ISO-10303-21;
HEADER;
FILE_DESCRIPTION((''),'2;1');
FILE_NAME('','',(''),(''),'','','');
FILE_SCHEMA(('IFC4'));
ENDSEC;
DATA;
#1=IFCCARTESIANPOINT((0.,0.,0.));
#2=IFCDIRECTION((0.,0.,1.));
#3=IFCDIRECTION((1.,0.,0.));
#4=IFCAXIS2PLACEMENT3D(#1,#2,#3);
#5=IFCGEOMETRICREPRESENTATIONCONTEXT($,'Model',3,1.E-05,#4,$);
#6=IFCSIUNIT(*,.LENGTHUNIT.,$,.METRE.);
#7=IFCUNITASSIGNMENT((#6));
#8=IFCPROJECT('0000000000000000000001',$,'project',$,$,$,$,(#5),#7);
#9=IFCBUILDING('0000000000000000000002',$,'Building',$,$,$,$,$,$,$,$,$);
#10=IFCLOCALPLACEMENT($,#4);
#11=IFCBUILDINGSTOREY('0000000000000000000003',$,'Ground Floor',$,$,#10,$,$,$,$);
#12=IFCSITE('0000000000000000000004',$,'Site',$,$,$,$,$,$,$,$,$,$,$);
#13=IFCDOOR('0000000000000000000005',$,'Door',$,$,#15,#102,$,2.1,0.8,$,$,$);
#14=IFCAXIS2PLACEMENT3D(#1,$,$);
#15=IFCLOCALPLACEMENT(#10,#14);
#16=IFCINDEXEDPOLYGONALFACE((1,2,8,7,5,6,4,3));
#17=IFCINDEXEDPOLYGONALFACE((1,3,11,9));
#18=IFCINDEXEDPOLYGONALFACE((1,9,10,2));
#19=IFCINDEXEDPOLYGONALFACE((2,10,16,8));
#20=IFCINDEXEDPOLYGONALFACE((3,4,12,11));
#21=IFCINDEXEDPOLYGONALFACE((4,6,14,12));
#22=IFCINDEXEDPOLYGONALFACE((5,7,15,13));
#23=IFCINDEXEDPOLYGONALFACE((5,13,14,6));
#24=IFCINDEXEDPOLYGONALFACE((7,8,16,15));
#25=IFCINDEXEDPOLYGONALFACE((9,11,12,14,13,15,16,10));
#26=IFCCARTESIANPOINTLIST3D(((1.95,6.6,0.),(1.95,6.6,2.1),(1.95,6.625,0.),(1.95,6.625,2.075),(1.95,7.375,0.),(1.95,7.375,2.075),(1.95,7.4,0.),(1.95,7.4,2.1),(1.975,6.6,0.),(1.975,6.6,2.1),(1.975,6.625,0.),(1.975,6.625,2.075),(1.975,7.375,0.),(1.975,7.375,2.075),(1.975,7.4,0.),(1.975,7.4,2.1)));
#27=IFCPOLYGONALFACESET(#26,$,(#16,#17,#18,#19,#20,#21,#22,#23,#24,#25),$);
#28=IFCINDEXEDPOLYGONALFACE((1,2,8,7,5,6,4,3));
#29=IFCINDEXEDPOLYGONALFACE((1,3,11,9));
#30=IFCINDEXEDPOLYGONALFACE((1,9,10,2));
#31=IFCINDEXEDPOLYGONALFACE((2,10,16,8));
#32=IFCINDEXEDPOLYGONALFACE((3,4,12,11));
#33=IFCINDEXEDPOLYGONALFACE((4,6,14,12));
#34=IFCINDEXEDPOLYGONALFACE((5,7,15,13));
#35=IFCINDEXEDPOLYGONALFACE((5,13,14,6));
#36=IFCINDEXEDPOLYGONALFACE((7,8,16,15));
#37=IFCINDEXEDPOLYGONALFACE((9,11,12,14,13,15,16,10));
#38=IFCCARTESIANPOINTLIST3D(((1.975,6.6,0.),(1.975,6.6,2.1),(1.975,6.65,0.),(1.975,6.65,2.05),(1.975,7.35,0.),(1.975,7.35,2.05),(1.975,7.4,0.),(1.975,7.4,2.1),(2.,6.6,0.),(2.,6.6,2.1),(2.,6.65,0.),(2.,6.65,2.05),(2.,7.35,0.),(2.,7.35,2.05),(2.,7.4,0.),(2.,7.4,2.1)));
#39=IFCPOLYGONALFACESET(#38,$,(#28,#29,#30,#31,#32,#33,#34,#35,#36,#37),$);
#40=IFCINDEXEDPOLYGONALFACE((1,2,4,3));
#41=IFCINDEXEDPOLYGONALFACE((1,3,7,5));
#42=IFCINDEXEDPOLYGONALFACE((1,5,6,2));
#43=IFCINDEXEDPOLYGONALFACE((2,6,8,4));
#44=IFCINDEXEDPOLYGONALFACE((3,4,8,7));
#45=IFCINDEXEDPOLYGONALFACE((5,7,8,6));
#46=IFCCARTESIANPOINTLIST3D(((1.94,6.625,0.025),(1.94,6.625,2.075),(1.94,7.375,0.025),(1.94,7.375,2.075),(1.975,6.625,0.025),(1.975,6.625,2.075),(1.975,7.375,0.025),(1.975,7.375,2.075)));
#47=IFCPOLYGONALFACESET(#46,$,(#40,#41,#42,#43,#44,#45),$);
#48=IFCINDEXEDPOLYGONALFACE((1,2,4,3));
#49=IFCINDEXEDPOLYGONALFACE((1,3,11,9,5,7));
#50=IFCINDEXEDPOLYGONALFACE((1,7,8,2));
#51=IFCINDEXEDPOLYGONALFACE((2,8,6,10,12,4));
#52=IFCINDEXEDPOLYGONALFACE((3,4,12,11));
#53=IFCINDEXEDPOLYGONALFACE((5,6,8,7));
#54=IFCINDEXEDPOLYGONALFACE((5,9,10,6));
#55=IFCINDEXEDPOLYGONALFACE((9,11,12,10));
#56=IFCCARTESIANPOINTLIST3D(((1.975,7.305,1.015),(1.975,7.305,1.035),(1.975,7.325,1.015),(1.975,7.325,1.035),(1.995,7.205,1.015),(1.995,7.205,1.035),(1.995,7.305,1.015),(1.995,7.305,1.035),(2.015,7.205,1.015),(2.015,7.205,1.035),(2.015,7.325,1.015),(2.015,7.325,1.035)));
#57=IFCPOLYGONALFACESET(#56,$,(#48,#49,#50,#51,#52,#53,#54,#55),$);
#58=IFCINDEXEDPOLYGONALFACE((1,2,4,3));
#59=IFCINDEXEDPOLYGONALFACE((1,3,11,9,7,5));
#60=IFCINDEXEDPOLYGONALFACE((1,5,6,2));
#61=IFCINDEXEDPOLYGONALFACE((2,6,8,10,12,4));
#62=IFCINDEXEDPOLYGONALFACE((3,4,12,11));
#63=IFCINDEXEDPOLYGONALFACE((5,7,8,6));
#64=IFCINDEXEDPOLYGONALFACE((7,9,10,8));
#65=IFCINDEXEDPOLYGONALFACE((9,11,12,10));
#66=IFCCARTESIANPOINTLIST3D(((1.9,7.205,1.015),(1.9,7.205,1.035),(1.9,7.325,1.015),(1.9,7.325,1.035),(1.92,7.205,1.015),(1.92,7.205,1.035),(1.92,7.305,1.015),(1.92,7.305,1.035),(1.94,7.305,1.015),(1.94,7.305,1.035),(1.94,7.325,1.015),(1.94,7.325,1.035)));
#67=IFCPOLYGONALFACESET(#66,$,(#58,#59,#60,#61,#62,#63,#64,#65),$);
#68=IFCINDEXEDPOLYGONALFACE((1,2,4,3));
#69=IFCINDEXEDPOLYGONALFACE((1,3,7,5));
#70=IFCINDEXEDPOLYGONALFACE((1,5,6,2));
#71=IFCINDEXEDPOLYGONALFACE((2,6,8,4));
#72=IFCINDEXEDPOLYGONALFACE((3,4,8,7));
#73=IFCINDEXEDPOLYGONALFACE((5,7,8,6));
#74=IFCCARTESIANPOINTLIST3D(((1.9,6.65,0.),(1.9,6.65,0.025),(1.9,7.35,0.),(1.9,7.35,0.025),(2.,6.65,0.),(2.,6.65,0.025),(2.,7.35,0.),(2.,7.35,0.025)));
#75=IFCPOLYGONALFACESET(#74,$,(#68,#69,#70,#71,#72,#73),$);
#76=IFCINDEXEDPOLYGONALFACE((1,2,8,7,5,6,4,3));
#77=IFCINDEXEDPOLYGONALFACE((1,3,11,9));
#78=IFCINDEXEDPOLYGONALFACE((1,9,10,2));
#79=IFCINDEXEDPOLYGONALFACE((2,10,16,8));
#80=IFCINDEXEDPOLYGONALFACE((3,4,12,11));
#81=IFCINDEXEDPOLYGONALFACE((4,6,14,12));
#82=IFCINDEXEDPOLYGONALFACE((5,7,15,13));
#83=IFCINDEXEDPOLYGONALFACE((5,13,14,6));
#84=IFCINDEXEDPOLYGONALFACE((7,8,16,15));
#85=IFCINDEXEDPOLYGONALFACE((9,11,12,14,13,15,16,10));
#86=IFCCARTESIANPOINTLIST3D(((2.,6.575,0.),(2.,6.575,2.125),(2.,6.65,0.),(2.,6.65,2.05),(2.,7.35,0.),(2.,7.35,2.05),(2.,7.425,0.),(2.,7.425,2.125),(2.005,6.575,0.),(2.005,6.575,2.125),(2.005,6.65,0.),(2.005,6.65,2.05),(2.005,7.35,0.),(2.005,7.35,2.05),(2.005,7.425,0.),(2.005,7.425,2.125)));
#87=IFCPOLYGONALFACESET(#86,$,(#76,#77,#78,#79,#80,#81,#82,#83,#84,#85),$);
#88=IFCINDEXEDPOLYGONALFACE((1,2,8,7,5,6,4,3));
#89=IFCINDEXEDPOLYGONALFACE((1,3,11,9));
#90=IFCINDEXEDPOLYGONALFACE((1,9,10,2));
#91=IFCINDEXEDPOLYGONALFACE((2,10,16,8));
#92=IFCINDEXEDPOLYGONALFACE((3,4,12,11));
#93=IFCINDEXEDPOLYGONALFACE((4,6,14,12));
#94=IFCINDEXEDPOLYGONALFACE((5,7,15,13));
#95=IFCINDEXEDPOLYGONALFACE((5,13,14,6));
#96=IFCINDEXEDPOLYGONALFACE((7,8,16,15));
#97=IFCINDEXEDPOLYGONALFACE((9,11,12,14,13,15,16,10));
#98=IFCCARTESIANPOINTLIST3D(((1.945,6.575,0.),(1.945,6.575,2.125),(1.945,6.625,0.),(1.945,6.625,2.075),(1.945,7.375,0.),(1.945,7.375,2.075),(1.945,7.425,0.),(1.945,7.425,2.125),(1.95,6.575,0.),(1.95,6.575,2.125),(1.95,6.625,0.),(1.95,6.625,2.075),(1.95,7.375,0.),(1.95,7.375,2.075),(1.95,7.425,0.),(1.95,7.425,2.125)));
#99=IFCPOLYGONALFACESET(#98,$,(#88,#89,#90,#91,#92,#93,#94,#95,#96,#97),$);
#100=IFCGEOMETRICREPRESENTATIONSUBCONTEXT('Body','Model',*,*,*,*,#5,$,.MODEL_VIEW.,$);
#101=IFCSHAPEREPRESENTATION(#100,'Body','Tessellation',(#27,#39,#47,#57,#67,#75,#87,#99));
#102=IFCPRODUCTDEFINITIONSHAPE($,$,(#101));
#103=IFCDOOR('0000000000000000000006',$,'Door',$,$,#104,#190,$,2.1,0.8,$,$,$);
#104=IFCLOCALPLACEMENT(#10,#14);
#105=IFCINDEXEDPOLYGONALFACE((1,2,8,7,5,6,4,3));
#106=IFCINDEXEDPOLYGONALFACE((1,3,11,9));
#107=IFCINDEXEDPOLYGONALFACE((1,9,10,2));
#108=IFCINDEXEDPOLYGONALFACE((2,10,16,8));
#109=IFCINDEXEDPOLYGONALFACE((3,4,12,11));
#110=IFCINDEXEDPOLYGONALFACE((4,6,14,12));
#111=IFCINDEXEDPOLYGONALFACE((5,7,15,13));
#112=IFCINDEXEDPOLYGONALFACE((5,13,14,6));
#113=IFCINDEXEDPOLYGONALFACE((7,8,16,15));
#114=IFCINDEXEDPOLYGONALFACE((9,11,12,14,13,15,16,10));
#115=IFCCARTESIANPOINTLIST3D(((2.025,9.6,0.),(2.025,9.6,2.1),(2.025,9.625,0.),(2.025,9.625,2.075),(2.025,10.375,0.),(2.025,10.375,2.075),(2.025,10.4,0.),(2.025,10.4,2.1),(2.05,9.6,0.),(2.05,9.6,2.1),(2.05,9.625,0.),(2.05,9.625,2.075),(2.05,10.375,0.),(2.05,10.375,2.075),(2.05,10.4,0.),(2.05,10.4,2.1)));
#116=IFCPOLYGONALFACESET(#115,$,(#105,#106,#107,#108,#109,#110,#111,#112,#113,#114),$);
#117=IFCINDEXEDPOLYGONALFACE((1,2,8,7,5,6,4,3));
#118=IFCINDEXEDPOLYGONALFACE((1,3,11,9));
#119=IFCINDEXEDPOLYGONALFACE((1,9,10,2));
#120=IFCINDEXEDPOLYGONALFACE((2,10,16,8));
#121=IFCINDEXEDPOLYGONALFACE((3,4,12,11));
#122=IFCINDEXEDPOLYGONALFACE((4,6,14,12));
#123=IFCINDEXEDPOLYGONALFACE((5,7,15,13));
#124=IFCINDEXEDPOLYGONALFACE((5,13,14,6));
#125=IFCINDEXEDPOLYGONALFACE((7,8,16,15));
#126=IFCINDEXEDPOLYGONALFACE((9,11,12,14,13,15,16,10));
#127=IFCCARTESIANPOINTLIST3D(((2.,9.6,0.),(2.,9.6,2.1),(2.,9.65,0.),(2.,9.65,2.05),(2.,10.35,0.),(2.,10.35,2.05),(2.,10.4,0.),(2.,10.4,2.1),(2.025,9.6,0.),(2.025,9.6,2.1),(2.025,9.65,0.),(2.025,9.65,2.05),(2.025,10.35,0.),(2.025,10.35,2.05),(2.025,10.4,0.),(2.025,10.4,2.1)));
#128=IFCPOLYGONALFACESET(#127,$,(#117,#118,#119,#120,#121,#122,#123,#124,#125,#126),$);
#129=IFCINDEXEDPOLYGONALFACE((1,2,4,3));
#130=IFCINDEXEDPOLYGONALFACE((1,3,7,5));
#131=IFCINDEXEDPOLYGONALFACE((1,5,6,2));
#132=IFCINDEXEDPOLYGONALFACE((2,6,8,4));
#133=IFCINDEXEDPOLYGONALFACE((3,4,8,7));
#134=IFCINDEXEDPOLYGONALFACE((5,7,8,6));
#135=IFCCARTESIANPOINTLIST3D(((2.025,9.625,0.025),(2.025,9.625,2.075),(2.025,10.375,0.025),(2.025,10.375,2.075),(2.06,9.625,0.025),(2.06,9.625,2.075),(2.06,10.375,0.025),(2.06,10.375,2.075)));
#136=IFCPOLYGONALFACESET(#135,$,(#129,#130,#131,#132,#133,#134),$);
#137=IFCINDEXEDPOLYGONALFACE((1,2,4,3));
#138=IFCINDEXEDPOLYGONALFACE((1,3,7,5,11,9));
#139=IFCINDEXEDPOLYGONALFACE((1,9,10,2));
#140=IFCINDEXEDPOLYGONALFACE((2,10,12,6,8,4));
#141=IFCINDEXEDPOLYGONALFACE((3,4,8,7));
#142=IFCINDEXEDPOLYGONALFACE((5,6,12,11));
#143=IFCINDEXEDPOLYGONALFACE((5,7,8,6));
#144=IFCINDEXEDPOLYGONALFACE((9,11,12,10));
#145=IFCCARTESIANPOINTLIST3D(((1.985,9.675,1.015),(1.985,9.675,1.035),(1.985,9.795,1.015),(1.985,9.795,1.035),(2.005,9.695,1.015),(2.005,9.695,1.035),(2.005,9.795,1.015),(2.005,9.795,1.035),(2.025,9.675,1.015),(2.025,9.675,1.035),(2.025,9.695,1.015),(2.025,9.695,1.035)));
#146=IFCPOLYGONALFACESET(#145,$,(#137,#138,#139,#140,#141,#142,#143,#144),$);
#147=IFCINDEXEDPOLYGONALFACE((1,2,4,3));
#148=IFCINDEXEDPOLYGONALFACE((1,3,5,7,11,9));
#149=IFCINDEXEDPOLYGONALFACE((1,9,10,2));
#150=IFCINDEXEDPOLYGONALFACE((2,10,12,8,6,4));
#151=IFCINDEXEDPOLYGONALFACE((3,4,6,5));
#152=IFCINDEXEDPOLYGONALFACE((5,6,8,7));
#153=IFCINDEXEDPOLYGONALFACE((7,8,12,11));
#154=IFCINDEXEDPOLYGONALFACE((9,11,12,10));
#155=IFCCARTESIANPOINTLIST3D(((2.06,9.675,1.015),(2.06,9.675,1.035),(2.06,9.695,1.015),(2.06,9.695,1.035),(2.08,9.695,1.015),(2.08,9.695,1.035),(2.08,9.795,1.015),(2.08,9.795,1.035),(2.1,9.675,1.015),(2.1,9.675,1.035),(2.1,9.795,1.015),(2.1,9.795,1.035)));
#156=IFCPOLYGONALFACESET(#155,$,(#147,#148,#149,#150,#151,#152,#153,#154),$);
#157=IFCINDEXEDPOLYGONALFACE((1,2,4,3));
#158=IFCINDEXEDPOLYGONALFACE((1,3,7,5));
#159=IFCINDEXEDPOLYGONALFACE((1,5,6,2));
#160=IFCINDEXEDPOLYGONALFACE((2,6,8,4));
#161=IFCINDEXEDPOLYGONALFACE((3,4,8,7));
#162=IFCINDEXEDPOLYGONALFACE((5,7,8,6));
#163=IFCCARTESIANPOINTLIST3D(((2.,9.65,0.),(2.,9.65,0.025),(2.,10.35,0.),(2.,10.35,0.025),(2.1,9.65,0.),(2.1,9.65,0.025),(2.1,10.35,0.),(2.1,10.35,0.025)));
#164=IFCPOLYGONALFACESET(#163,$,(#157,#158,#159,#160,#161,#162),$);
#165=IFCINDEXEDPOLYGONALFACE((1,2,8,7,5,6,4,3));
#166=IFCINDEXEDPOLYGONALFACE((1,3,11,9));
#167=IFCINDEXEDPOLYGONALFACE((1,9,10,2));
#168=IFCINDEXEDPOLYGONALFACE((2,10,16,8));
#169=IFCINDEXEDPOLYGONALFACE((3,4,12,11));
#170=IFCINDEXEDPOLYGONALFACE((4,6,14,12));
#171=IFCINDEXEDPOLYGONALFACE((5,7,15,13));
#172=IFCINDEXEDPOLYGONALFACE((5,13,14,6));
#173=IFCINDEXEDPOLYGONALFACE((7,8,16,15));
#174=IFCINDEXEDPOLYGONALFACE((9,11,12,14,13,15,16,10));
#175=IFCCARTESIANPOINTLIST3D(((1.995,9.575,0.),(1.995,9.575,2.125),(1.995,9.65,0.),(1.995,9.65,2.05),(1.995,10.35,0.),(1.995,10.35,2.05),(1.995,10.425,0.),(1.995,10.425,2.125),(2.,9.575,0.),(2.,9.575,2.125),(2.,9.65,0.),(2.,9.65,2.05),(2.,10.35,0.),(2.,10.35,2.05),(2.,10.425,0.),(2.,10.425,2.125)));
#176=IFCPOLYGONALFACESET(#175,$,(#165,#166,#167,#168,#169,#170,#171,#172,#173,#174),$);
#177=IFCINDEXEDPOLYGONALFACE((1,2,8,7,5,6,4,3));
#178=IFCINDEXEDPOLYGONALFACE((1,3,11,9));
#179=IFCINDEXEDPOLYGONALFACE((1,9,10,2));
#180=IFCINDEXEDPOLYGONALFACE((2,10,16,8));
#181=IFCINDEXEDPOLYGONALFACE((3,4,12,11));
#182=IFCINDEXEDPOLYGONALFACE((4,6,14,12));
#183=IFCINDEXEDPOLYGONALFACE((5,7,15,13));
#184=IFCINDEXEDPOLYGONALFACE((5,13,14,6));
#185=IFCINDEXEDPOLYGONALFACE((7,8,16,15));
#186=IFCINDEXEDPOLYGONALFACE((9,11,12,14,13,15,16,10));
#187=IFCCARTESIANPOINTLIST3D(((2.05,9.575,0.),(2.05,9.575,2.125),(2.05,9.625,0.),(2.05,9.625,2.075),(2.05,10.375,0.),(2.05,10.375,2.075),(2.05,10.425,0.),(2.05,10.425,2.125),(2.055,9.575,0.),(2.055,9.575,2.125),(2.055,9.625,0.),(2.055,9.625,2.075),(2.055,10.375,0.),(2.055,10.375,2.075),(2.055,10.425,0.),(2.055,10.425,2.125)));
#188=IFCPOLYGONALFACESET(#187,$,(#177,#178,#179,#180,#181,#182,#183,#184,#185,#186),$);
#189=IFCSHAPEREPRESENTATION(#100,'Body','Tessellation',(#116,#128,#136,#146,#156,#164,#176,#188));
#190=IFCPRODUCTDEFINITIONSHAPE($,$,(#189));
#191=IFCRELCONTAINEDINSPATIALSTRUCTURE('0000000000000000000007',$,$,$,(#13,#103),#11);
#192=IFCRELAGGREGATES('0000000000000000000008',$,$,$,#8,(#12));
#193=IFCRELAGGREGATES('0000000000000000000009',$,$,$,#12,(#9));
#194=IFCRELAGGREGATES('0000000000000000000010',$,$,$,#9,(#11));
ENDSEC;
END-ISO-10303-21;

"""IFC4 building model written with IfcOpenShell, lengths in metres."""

from ifc_helpers import new_model, si_unit, frame, origin_with_axes, place, context, subcontext, project, spatial, line, indexed_curve, outline, extrude, element, save


model = new_model("IFC4")

# Units and contexts
model_context = context("Model", 3, precision=1e-05, world=origin_with_axes())
body_context = subcontext(model_context, "Body", "Model", "MODEL_VIEW")
ifc_project = project(units=[si_unit("LENGTHUNIT", "METRE")], contexts=[model_context])

# Site, building, storey
site = spatial("IfcSite", under=ifc_project, Name="Site")
building = spatial("IfcBuilding", under=site, Name="Building")
storey_placement = place(None, origin_with_axes())
storey = spatial("IfcBuildingStorey", under=building, at=storey_placement, Name="Ground Floor")

# Doors
door_1_placement = place(storey_placement, frame((2.0, 6.6, 0.0), z_axis=(0.0, 0.0, 1.0), x_axis=(0.0, 1.0, 0.0)))
element("IfcDoor", 1, at=door_1_placement, inside=storey, Name="Door", OverallHeight=2.1, OverallWidth=0.8, context=body_context, shape_type="SweptSolid", body=[
    extrude(outline(indexed_curve([(0.0, 0.0), (0.0, 2.1), (0.8, 2.1), (0.8, 0.0), (0.775, 0.0), (0.775, 2.075), (0.025, 2.075), (0.025, 0.0)], segments=[line(1, 2, 3, 4, 5, 6, 7, 8, 1)])), frame((0.0, 0.025, 0.0), z_axis=(0.0, -1.0, 0.0), x_axis=(1.0, 0.0, 0.0)), (0.0, 0.0, -1.0), 0.025),
    extrude(outline(indexed_curve([(0.0, 0.0), (0.0, 2.1), (0.8, 2.1), (0.8, 0.0), (0.75, 0.0), (0.75, 2.05), (0.05, 2.05), (0.05, 0.0)], segments=[line(1, 2, 3, 4, 5, 6, 7, 8, 1)])), frame((0.0, 0.0, 0.0), z_axis=(0.0, -1.0, 0.0), x_axis=(1.0, 0.0, 0.0)), (0.0, 0.0, -1.0), 0.025),
    extrude(outline(indexed_curve([(0.0, 0.0), (0.75, 0.0), (0.75, 0.035), (0.0, 0.035)], segments=[line(1, 2, 3, 4, 1)])), frame((0.025, 0.025, 0.025), z_axis=(0.0, 0.0, 1.0), x_axis=(1.0, 0.0, 0.0)), (0.0, 0.0, 1.0), 2.05),
    extrude(outline(indexed_curve([(0.0, 0.0), (0.0, -0.04), (-0.12, -0.04), (-0.12, -0.02), (-0.02, -0.02), (-0.02, 0.0)], segments=[line(1, 2, 3, 4, 5, 6, 1)])), frame((0.725, 0.025, 1.015), z_axis=(0.0, 0.0, 1.0), x_axis=(1.0, 0.0, 0.0)), (0.0, 0.0, 1.0), 0.02),
    extrude(outline(indexed_curve([(0.0, 0.0), (0.0, 0.04), (-0.12, 0.04), (-0.12, 0.02), (-0.02, 0.02), (-0.02, 0.0)], segments=[line(1, 2, 3, 4, 5, 6, 1)])), frame((0.725, 0.06, 1.015), z_axis=(0.0, 0.0, 1.0), x_axis=(1.0, 0.0, 0.0)), (0.0, 0.0, 1.0), 0.02),
    extrude(outline(indexed_curve([(0.0, 0.0), (0.7, 0.0), (0.7, 0.1), (0.0, 0.1)], segments=[line(1, 2, 3, 4, 1)])), frame((0.05, 0.0, 0.0), z_axis=(0.0, 0.0, 1.0), x_axis=(1.0, 0.0, 0.0)), (0.0, 0.0, 1.0), 0.025),
    extrude(outline(indexed_curve([(0.0, 0.0), (0.0, 2.125), (0.85, 2.125), (0.85, 0.0), (0.775, 0.0), (0.775, 2.05), (0.075, 2.05), (0.075, 0.0)], segments=[line(1, 2, 3, 4, 5, 6, 7, 8, 1)])), frame((-0.025, -0.005, 0.0), z_axis=(0.0, -1.0, 0.0), x_axis=(1.0, 0.0, 0.0)), (0.0, 0.0, -1.0), 0.005),
    extrude(outline(indexed_curve([(0.0, 0.0), (0.0, 2.125), (0.85, 2.125), (0.85, 0.0), (0.8, 0.0), (0.8, 2.075), (0.05, 2.075), (0.05, 0.0)], segments=[line(1, 2, 3, 4, 5, 6, 7, 8, 1)])), frame((-0.025, 0.05, 0.0), z_axis=(0.0, -1.0, 0.0), x_axis=(1.0, 0.0, 0.0)), (0.0, 0.0, -1.0), 0.005),
])
door_2_placement = place(storey_placement, frame((2.0, 10.4, 0.0), z_axis=(0.0, 0.0, 1.0), x_axis=(0.0, -1.0, 0.0)))
element("IfcDoor", 2, at=door_2_placement, inside=storey, Name="Door", OverallHeight=2.1, OverallWidth=0.8, context=body_context, shape_type="SweptSolid", body=[
    extrude(outline(indexed_curve([(0.0, 0.0), (0.0, 2.1), (0.8, 2.1), (0.8, 0.0), (0.775, 0.0), (0.775, 2.075), (0.025, 2.075), (0.025, 0.0)], segments=[line(1, 2, 3, 4, 5, 6, 7, 8, 1)])), frame((0.0, 0.025, 0.0), z_axis=(0.0, -1.0, 0.0), x_axis=(1.0, 0.0, 0.0)), (0.0, 0.0, -1.0), 0.025),
    extrude(outline(indexed_curve([(0.0, 0.0), (0.0, 2.1), (0.8, 2.1), (0.8, 0.0), (0.75, 0.0), (0.75, 2.05), (0.05, 2.05), (0.05, 0.0)], segments=[line(1, 2, 3, 4, 5, 6, 7, 8, 1)])), frame((0.0, 0.0, 0.0), z_axis=(0.0, -1.0, 0.0), x_axis=(1.0, 0.0, 0.0)), (0.0, 0.0, -1.0), 0.025),
    extrude(outline(indexed_curve([(0.0, 0.0), (0.75, 0.0), (0.75, 0.035), (0.0, 0.035)], segments=[line(1, 2, 3, 4, 1)])), frame((0.025, 0.025, 0.025), z_axis=(0.0, 0.0, 1.0), x_axis=(1.0, 0.0, 0.0)), (0.0, 0.0, 1.0), 2.05),
    extrude(outline(indexed_curve([(0.0, 0.0), (0.0, -0.04), (-0.12, -0.04), (-0.12, -0.02), (-0.02, -0.02), (-0.02, 0.0)], segments=[line(1, 2, 3, 4, 5, 6, 1)])), frame((0.725, 0.025, 1.015), z_axis=(0.0, 0.0, 1.0), x_axis=(1.0, 0.0, 0.0)), (0.0, 0.0, 1.0), 0.02),
    extrude(outline(indexed_curve([(0.0, 0.0), (0.0, 0.04), (-0.12, 0.04), (-0.12, 0.02), (-0.02, 0.02), (-0.02, 0.0)], segments=[line(1, 2, 3, 4, 5, 6, 1)])), frame((0.725, 0.06, 1.015), z_axis=(0.0, 0.0, 1.0), x_axis=(1.0, 0.0, 0.0)), (0.0, 0.0, 1.0), 0.02),
    extrude(outline(indexed_curve([(0.0, 0.0), (0.7, 0.0), (0.7, 0.1), (0.0, 0.1)], segments=[line(1, 2, 3, 4, 1)])), frame((0.05, 0.0, 0.0), z_axis=(0.0, 0.0, 1.0), x_axis=(1.0, 0.0, 0.0)), (0.0, 0.0, 1.0), 0.025),
    extrude(outline(indexed_curve([(0.0, 0.0), (0.0, 2.125), (0.85, 2.125), (0.85, 0.0), (0.775, 0.0), (0.775, 2.05), (0.075, 2.05), (0.075, 0.0)], segments=[line(1, 2, 3, 4, 5, 6, 7, 8, 1)])), frame((-0.025, -0.005, 0.0), z_axis=(0.0, -1.0, 0.0), x_axis=(1.0, 0.0, 0.0)), (0.0, 0.0, -1.0), 0.005),
    extrude(outline(indexed_curve([(0.0, 0.0), (0.0, 2.125), (0.85, 2.125), (0.85, 0.0), (0.8, 0.0), (0.8, 2.075), (0.05, 2.075), (0.05, 0.0)], segments=[line(1, 2, 3, 4, 5, 6, 7, 8, 1)])), frame((-0.025, 0.05, 0.0), z_axis=(0.0, -1.0, 0.0), x_axis=(1.0, 0.0, 0.0)), (0.0, 0.0, -1.0), 0.005),
])

save(model, "model.ifc")
